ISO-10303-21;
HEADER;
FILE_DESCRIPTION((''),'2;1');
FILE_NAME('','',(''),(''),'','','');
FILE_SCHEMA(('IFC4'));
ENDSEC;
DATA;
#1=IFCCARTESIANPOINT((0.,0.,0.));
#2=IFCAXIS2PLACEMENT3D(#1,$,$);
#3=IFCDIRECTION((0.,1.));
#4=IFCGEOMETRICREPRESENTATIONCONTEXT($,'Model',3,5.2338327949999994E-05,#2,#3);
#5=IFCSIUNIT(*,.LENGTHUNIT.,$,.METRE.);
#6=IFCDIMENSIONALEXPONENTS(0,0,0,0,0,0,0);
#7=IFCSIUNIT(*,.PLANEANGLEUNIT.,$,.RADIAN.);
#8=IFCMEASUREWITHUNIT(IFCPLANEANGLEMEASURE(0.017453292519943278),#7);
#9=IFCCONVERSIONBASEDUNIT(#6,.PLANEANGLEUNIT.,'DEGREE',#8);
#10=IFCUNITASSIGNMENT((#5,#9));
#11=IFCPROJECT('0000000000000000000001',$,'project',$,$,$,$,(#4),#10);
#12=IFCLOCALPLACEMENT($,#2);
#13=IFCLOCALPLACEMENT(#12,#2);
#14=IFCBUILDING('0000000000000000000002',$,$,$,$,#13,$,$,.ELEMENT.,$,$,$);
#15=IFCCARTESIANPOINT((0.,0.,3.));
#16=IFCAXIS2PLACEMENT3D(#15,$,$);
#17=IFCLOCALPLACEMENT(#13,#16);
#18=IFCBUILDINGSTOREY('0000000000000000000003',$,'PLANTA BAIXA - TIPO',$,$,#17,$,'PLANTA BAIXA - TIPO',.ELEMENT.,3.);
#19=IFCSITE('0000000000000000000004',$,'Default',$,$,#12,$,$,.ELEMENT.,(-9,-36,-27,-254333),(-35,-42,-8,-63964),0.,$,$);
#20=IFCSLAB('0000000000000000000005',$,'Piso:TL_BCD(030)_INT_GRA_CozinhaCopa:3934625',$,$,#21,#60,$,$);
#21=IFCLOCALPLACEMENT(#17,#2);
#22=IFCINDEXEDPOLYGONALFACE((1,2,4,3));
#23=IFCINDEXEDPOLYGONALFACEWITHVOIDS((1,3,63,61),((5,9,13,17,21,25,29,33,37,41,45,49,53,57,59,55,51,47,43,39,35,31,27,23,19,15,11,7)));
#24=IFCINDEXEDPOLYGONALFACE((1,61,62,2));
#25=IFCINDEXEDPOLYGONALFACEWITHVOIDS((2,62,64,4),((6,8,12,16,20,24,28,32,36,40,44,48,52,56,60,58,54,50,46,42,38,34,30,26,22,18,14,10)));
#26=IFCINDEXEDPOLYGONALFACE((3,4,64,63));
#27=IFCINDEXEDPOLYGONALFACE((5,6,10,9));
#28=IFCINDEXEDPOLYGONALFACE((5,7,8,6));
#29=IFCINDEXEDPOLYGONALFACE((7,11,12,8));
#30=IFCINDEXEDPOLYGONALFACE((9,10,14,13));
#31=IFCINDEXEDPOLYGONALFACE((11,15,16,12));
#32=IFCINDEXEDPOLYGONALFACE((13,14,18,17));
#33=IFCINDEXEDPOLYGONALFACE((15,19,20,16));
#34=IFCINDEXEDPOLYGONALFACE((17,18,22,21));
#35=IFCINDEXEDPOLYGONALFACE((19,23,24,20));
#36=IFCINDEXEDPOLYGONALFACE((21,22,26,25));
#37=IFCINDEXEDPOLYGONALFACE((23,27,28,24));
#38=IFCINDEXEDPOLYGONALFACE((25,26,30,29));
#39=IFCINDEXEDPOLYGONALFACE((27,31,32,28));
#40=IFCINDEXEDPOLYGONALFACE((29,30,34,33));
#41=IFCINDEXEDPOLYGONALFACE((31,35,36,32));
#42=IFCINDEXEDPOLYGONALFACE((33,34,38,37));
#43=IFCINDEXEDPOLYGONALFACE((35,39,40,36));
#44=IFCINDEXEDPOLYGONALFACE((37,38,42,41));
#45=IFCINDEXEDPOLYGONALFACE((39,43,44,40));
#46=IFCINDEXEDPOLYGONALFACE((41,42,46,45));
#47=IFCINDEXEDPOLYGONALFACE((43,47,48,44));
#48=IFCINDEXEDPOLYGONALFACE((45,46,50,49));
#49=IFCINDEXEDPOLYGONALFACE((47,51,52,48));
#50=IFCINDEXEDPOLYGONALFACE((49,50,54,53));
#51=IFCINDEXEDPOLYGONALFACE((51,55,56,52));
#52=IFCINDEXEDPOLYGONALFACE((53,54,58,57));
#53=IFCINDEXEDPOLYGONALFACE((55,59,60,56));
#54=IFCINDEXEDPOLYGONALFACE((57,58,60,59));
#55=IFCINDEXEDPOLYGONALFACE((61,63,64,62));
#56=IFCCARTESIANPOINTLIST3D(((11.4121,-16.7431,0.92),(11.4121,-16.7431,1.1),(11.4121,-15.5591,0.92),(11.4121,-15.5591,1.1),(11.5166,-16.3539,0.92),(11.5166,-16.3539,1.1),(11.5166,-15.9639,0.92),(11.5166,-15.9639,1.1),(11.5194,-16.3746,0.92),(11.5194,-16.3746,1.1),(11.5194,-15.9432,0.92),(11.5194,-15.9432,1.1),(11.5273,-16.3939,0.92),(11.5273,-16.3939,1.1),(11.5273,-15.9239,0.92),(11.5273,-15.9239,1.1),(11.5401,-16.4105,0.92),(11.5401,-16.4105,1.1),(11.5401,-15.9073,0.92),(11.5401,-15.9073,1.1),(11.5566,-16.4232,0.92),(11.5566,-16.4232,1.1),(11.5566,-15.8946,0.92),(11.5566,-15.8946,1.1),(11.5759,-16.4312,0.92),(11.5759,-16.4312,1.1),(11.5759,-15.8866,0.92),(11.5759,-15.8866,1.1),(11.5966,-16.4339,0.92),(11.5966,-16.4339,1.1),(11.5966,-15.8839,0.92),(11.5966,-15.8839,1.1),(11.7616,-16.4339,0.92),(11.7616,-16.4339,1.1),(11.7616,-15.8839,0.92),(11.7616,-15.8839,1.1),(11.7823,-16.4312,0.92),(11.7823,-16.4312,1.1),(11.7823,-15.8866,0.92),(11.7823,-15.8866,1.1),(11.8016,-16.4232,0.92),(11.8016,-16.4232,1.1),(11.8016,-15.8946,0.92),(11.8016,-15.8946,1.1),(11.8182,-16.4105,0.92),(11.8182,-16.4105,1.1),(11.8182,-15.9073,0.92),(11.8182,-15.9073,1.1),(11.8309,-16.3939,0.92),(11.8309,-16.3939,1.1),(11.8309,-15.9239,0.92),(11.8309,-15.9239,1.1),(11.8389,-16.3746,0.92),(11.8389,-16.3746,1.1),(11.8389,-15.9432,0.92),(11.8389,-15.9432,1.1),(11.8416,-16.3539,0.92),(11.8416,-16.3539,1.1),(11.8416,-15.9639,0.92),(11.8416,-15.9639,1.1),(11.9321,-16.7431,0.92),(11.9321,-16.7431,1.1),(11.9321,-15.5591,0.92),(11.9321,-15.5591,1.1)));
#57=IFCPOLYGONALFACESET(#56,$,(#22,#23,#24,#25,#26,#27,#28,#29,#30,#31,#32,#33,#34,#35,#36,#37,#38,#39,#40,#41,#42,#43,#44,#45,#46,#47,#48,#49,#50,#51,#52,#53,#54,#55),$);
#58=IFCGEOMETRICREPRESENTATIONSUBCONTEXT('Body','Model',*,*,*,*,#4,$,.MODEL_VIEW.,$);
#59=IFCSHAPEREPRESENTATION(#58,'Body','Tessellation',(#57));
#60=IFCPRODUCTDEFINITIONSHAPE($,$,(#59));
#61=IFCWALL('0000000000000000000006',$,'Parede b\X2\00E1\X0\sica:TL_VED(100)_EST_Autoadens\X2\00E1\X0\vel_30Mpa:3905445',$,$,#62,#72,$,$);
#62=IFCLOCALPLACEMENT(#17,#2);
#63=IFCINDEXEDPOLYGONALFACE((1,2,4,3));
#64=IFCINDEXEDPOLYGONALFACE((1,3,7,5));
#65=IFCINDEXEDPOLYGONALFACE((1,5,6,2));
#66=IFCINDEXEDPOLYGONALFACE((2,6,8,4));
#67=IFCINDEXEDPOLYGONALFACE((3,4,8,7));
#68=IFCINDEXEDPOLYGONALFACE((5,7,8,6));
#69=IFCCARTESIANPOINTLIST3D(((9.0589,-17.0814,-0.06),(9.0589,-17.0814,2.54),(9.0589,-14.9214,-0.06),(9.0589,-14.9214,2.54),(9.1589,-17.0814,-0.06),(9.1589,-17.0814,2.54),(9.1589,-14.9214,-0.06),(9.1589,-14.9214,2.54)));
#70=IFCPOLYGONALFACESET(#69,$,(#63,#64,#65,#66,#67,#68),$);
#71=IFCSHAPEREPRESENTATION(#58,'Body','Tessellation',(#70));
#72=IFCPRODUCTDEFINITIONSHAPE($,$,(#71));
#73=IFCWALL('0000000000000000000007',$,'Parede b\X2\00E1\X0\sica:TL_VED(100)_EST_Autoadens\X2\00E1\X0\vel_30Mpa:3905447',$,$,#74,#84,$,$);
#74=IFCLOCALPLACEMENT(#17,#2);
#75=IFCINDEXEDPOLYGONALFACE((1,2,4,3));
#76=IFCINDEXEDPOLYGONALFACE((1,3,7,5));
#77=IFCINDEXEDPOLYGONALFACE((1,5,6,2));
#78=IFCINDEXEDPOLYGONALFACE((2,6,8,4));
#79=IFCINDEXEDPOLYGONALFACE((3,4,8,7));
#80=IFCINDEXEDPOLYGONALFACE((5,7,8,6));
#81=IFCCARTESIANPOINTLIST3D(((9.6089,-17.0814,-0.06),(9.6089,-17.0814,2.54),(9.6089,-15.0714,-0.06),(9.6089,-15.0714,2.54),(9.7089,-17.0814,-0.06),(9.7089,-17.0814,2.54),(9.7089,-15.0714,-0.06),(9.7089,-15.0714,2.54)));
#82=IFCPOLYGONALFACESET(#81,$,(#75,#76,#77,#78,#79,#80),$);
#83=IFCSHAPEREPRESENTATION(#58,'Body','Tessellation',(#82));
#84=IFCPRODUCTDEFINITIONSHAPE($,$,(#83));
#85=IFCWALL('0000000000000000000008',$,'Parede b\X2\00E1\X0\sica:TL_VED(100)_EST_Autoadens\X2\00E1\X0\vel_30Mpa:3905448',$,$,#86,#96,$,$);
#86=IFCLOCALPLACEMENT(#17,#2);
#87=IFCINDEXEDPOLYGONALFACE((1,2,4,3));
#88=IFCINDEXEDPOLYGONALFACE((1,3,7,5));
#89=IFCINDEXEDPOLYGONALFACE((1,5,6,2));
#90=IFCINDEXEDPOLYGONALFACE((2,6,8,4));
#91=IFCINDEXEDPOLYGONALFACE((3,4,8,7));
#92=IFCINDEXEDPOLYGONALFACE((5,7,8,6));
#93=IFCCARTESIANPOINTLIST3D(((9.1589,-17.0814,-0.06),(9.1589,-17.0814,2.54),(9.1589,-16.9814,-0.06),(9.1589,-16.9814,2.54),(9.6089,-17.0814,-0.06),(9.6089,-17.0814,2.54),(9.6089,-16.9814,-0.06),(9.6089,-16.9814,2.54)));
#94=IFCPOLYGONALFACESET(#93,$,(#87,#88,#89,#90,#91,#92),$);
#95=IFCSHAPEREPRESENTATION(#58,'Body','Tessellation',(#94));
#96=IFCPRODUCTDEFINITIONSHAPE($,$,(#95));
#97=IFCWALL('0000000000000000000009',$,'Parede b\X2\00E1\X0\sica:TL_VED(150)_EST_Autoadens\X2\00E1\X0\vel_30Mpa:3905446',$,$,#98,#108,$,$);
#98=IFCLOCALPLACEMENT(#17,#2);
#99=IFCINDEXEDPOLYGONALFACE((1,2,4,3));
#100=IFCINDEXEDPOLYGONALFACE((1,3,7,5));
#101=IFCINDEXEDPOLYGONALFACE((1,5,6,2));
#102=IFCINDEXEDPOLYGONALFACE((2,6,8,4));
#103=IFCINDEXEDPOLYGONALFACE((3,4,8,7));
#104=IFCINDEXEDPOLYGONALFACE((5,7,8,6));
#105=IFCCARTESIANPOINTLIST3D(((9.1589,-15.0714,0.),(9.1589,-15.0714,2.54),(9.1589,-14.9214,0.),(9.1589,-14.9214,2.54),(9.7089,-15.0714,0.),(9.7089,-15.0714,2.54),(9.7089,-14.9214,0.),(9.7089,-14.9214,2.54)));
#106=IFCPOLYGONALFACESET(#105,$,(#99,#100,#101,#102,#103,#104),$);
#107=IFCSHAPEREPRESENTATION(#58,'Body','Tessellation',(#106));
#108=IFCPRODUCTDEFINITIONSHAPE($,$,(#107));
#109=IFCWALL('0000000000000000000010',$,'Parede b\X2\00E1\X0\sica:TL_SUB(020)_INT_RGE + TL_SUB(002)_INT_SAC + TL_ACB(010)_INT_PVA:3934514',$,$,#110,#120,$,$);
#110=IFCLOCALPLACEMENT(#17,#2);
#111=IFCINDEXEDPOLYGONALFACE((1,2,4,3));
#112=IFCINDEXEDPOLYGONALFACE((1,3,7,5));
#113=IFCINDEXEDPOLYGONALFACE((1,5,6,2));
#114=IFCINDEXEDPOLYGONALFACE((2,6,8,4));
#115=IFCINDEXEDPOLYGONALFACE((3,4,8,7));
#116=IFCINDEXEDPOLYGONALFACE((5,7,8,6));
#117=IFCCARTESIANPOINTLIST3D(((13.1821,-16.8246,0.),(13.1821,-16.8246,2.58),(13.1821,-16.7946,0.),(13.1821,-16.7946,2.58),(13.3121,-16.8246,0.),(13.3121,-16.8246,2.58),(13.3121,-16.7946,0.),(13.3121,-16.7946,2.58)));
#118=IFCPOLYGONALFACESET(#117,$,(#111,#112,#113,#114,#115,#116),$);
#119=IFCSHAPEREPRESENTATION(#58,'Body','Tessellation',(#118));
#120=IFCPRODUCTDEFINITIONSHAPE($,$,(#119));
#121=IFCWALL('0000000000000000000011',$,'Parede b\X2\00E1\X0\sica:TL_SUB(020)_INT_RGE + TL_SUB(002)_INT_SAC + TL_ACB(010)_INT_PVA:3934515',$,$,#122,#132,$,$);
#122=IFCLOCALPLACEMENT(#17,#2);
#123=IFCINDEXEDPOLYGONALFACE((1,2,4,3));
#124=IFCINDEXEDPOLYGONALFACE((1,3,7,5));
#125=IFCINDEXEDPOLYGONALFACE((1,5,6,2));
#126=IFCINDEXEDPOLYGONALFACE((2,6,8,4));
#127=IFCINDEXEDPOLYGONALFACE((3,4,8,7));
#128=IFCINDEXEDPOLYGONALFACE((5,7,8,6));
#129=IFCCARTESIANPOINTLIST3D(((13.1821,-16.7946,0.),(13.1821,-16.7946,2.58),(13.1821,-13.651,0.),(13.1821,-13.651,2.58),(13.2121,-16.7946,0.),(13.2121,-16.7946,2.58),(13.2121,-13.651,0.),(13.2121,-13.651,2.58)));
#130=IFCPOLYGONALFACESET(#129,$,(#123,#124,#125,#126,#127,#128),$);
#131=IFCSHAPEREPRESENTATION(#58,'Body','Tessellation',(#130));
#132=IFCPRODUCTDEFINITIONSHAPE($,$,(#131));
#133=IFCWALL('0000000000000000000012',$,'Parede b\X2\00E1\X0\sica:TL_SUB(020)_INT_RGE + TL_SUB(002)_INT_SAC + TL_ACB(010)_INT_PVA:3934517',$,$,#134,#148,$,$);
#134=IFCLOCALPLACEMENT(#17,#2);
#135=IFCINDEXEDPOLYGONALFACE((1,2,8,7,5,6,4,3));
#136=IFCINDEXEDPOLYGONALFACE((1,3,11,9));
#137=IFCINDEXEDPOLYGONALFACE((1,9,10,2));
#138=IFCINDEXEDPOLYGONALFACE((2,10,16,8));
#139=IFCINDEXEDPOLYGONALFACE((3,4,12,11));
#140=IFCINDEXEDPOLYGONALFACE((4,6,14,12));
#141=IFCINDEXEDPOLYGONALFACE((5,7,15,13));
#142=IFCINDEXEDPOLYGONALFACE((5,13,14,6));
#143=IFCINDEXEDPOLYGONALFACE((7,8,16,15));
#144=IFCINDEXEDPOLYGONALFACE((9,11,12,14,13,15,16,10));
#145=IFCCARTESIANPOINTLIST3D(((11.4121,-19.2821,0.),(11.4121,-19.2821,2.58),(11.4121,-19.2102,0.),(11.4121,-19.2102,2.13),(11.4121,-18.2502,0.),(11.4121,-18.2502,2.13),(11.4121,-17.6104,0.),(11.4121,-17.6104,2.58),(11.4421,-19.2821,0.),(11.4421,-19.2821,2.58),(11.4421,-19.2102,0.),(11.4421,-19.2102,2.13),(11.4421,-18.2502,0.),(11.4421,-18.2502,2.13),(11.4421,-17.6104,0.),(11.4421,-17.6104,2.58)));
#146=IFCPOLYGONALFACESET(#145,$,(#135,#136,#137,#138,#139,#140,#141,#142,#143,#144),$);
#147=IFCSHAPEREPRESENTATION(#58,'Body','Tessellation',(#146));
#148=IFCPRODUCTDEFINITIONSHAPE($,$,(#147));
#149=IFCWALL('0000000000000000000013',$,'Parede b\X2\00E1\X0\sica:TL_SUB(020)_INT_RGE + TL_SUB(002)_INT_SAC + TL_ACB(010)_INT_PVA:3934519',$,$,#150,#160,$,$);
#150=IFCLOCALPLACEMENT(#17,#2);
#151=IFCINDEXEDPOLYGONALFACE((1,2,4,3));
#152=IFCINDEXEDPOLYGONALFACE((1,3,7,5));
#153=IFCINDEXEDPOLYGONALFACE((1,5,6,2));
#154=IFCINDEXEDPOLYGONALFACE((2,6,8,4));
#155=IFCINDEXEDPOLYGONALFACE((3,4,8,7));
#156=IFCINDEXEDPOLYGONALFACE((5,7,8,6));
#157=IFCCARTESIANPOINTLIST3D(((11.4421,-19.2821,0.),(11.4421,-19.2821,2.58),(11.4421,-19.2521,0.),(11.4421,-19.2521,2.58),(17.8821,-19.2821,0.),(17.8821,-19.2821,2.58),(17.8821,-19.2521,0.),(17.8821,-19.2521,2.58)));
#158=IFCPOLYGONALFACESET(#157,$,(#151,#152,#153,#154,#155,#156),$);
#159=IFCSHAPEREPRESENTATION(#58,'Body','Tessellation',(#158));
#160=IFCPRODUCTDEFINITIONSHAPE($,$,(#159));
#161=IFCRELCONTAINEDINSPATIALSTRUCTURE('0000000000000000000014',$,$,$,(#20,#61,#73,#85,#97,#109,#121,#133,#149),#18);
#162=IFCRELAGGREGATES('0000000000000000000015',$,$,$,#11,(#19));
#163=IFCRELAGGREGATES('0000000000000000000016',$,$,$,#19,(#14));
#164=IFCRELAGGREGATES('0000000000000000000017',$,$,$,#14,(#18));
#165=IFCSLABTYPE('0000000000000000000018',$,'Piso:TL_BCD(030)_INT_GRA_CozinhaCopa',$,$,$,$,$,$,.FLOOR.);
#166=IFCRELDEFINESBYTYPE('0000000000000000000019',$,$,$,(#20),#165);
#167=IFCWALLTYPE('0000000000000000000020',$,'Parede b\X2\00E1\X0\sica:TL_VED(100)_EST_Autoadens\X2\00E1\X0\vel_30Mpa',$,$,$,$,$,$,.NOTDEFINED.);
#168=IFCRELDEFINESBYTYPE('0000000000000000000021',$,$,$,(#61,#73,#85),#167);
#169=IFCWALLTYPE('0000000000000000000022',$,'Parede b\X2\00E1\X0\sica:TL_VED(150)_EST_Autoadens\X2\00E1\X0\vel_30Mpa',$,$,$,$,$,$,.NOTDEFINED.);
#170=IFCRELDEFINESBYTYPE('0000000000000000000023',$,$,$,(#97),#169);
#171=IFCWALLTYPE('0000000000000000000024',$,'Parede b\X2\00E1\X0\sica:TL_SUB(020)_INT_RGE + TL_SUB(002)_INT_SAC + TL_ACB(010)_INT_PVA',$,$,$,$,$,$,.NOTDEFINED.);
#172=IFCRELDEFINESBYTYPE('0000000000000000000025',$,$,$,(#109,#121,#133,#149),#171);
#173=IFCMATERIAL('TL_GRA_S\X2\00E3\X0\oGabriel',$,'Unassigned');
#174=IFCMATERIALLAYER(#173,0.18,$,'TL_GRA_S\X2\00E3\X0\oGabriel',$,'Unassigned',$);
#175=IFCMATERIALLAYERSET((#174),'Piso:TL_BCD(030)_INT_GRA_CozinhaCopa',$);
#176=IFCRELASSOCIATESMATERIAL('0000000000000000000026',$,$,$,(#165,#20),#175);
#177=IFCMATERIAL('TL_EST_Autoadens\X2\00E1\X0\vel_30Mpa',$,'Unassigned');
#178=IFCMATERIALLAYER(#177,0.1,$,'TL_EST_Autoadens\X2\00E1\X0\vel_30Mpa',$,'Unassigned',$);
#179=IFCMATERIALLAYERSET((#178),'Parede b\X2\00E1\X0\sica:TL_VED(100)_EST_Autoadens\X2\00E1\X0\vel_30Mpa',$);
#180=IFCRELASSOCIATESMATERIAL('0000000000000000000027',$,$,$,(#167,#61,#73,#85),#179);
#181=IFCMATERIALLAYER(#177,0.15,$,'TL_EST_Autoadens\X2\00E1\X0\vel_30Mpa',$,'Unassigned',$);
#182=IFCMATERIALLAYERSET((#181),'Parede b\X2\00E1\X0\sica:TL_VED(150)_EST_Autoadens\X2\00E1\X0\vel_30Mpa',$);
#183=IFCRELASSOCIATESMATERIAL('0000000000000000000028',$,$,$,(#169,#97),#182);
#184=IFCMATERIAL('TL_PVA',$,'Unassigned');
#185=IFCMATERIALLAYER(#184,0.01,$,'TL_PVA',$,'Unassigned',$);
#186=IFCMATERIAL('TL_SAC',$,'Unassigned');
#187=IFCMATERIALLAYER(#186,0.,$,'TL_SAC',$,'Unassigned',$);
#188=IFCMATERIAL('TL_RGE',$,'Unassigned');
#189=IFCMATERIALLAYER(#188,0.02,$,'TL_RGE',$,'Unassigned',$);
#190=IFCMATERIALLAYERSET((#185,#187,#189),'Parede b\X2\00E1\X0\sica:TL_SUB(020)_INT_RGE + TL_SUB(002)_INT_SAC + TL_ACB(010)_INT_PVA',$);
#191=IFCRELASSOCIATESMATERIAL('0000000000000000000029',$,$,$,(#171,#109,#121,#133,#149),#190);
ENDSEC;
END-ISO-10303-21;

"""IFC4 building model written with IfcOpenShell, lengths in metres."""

from ifc_helpers import new_model, entity, si_unit, converted_unit, direction, frame, frame_2d, origin, place, context, subcontext, project, spatial, polyline, circle_curve, parameter, trimmed, segment, composite_curve, rectangle, outline, extrude, material, layer, layer_set, layer_usage, type_object, element, save


model = new_model("IFC4")

# Units and contexts
model_context = context("Model", 3, precision=5.2338327949999994e-05, world=origin(), true_north=direction((0.0, 1.0)))
body_context = subcontext(model_context, "Body", "Model", "MODEL_VIEW")
ifc_project = project(units=[si_unit("LENGTHUNIT", "METRE"), converted_unit("PLANEANGLEUNIT", "DEGREE", entity("IfcPlaneAngleMeasure", 0.017453292519943278), si_unit("PLANEANGLEUNIT", "RADIAN"), dimensions=[0, 0, 0, 0, 0, 0, 0])], contexts=[model_context])

# Site, building, storey
site_placement = place(None, frame((0.0, 0.0, 0.0)))
site = spatial("IfcSite", under=ifc_project, at=site_placement, Name="Default", CompositionType="ELEMENT", RefLatitude=(-9, -36, -27, -254333), RefLongitude=(-35, -42, -8, -63964), RefElevation=0.0)
building_placement = place(site_placement, origin())
building = spatial("IfcBuilding", under=site, at=building_placement, CompositionType="ELEMENT")
storey_placement = place(building_placement, frame((0.0, 0.0, 3.0)))
storey = spatial("IfcBuildingStorey", under=building, at=storey_placement, Name="PLANTA BAIXA - TIPO", LongName="PLANTA BAIXA - TIPO", CompositionType="ELEMENT", Elevation=3.0)

# Slab, opening
ifc_material_1 = material(Name="TL_GRA_SãoGabriel", Category="Unassigned")
ifc_layer_1 = layer(ifc_material_1, 0.18, Name="TL_GRA_SãoGabriel", Category="Unassigned")
ifc_layer_set_1 = layer_set([ifc_layer_1], Name="Piso:TL_BCD(030)_INT_GRA_CozinhaCopa")
ifc_layer_usage_1 = layer_usage(ifc_layer_set_1, "AXIS3", "POSITIVE", 0.0)
slab_type_1 = type_object("IfcSlabType", Name="Piso:TL_BCD(030)_INT_GRA_CozinhaCopa", PredefinedType="FLOOR", material=ifc_layer_set_1)
slab_1_placement = place(storey_placement, frame((11.4121, -16.7431, 0.92)))
slab_1 = element("IfcSlab", 1, at=slab_1_placement, inside=storey, type_object=slab_type_1, material=ifc_layer_usage_1, Name="Piso:TL_BCD(030)_INT_GRA_CozinhaCopa:3934625", context=body_context, shape_type="SweptSolid", body=[
    extrude(rectangle(XDim=0.52, YDim=1.184, at=frame_2d((0.0, 0.0), x_axis=(-1.0, 0.0))), frame((0.26, 0.592, 0.18), z_axis=(0.0, 0.0, -1.0), x_axis=(-1.0, 0.0, 0.0)), (0.0, 0.0, 1.0), 0.18),
])
opening_1_placement = place(slab_1_placement, frame((-11.4121, 16.7431, 0.18)))
element("IfcOpeningElement", 2, at=opening_1_placement, cuts=slab_1, PredefinedType="OPENING", context=body_context, shape_type="SweptSolid", body=[
    extrude(outline(composite_curve([segment(trimmed(circle_curve(frame_2d((0.195, -0.0825), x_axis=(1.0, 0.0)), 0.08), [parameter(270.0)], [parameter(0.0)], True, "PARAMETER"), True, "CONTINUOUS"), segment(polyline([(0.275, -0.0825), (0.275, 0.0825)]), True, "CONTINUOUS"), segment(trimmed(circle_curve(frame_2d((0.195, 0.0825), x_axis=(1.0, 0.0)), 0.08), [parameter(0.0)], [parameter(90.0)], True, "PARAMETER"), True, "CONTINUOUS"), segment(polyline([(0.195, 0.1625), (-0.195, 0.1625)]), True, "CONTINUOUS"), segment(trimmed(circle_curve(frame_2d((-0.195, 0.0825), x_axis=(1.0, 0.0)), 0.08), [parameter(90.0)], [parameter(180.0)], True, "PARAMETER"), True, "CONTINUOUS"), segment(polyline([(-0.275, 0.0825), (-0.275, -0.0825)]), True, "CONTINUOUS"), segment(trimmed(circle_curve(frame_2d((-0.195, -0.0825), x_axis=(1.0, 0.0)), 0.08), [parameter(180.0)], [parameter(270.0)], True, "PARAMETER"), True, "CONTINUOUS"), segment(polyline([(-0.195, -0.1625), (0.195, -0.1625)]), True, "CONTINUOUS")], self_intersect=False)), frame((11.6791, -16.1589, -0.21), z_axis=(0.0, 0.0, 1.0), x_axis=(0.0, -1.0, 0.0)), (0.0, 0.0, 1.0), 0.21),
])

# Walls
ifc_material_2 = material(Name="TL_EST_Autoadensável_30Mpa", Category="Unassigned")
ifc_layer_2 = layer(ifc_material_2, 0.1, Name="TL_EST_Autoadensável_30Mpa", Category="Unassigned")
ifc_layer_set_2 = layer_set([ifc_layer_2], Name="Parede básica:TL_VED(100)_EST_Autoadensável_30Mpa")
ifc_layer_usage_2 = layer_usage(ifc_layer_set_2, "AXIS2", "NEGATIVE", 0.05)
wall_type_1 = type_object("IfcWallType", Name="Parede básica:TL_VED(100)_EST_Autoadensável_30Mpa", PredefinedType="NOTDEFINED", material=ifc_layer_set_2)
wall_1_placement = place(storey_placement, frame((9.1089, -17.0814, -0.06), z_axis=(0.0, 0.0, 1.0), x_axis=(0.0, 1.0, 0.0)))
element("IfcWall", 3, at=wall_1_placement, inside=storey, type_object=wall_type_1, material=ifc_layer_usage_2, Name="Parede básica:TL_VED(100)_EST_Autoadensável_30Mpa:3905445", context=body_context, shape_type="SweptSolid", body=[
    extrude(rectangle(XDim=2.16, YDim=0.1, at=frame_2d((1.08, 0.0), x_axis=(-1.0, 0.0))), origin(), (0.0, 0.0, 1.0), 2.6),
])
ifc_layer_usage_3 = layer_usage(ifc_layer_set_2, "AXIS2", "NEGATIVE", 0.05)
wall_2_placement = place(storey_placement, frame((9.6589, -15.0714, -0.06), z_axis=(0.0, 0.0, 1.0), x_axis=(0.0, -1.0, 0.0)))
element("IfcWall", 4, at=wall_2_placement, inside=storey, type_object=wall_type_1, material=ifc_layer_usage_3, Name="Parede básica:TL_VED(100)_EST_Autoadensável_30Mpa:3905447", context=body_context, shape_type="SweptSolid", body=[
    extrude(rectangle(XDim=2.01, YDim=0.1, at=frame_2d((1.005, 0.0), x_axis=(-1.0, 0.0))), origin(), (0.0, 0.0, 1.0), 2.6),
])
ifc_layer_usage_4 = layer_usage(ifc_layer_set_2, "AXIS2", "NEGATIVE", 0.05)
wall_3_placement = place(storey_placement, frame((9.6089, -17.0314, -0.06), z_axis=(0.0, 0.0, 1.0), x_axis=(-1.0, 0.0, 0.0)))
element("IfcWall", 5, at=wall_3_placement, inside=storey, type_object=wall_type_1, material=ifc_layer_usage_4, Name="Parede básica:TL_VED(100)_EST_Autoadensável_30Mpa:3905448", context=body_context, shape_type="SweptSolid", body=[
    extrude(rectangle(XDim=0.45, YDim=0.1, at=frame_2d((0.225, 0.0), x_axis=(-1.0, 0.0))), origin(), (0.0, 0.0, 1.0), 2.6),
])
ifc_layer_3 = layer(ifc_material_2, 0.15, Name="TL_EST_Autoadensável_30Mpa", Category="Unassigned")
ifc_layer_set_3 = layer_set([ifc_layer_3], Name="Parede básica:TL_VED(150)_EST_Autoadensável_30Mpa")
ifc_layer_usage_5 = layer_usage(ifc_layer_set_3, "AXIS2", "NEGATIVE", 0.075)
wall_type_2 = type_object("IfcWallType", Name="Parede básica:TL_VED(150)_EST_Autoadensável_30Mpa", PredefinedType="NOTDEFINED", material=ifc_layer_set_3)
wall_4_placement = place(storey_placement, frame((9.1589, -14.9964, 0.0)))
element("IfcWall", 6, at=wall_4_placement, inside=storey, type_object=wall_type_2, material=ifc_layer_usage_5, Name="Parede básica:TL_VED(150)_EST_Autoadensável_30Mpa:3905446", context=body_context, shape_type="SweptSolid", body=[
    extrude(rectangle(XDim=0.55, YDim=0.15, at=frame_2d((0.275, 0.0), x_axis=(-1.0, 0.0))), origin(), (0.0, 0.0, 1.0), 2.54),
])
ifc_material_3 = material(Name="TL_PVA", Category="Unassigned")
ifc_layer_4 = layer(ifc_material_3, 0.01, Name="TL_PVA", Category="Unassigned")
ifc_material_4 = material(Name="TL_SAC", Category="Unassigned")
ifc_layer_5 = layer(ifc_material_4, 0.0, Name="TL_SAC", Category="Unassigned")
ifc_material_5 = material(Name="TL_RGE", Category="Unassigned")
ifc_layer_6 = layer(ifc_material_5, 0.02, Name="TL_RGE", Category="Unassigned")
ifc_layer_set_4 = layer_set([ifc_layer_4, ifc_layer_5, ifc_layer_6], Name="Parede básica:TL_SUB(020)_INT_RGE + TL_SUB(002)_INT_SAC + TL_ACB(010)_INT_PVA")
ifc_layer_usage_6 = layer_usage(ifc_layer_set_4, "AXIS2", "POSITIVE", -0.015)
wall_type_3 = type_object("IfcWallType", Name="Parede básica:TL_SUB(020)_INT_RGE + TL_SUB(002)_INT_SAC + TL_ACB(010)_INT_PVA", PredefinedType="NOTDEFINED", material=ifc_layer_set_4)
wall_5_placement = place(storey_placement, frame((13.1821, -16.8096, 0.0)))
element("IfcWall", 7, at=wall_5_placement, inside=storey, type_object=wall_type_3, material=ifc_layer_usage_6, Name="Parede básica:TL_SUB(020)_INT_RGE + TL_SUB(002)_INT_SAC + TL_ACB(010)_INT_PVA:3934514", context=body_context, shape_type="SweptSolid", body=[
    extrude(rectangle(XDim=0.13, YDim=0.03, at=frame_2d((0.065, 0.0), x_axis=(-1.0, 0.0))), origin(), (0.0, 0.0, 1.0), 2.58),
])
ifc_layer_usage_7 = layer_usage(ifc_layer_set_4, "AXIS2", "POSITIVE", -0.015)
wall_6_placement = place(storey_placement, frame((13.1971, -13.651, 0.0), z_axis=(0.0, 0.0, 1.0), x_axis=(0.0, -1.0, 0.0)))
element("IfcWall", 8, at=wall_6_placement, inside=storey, type_object=wall_type_3, material=ifc_layer_usage_7, Name="Parede básica:TL_SUB(020)_INT_RGE + TL_SUB(002)_INT_SAC + TL_ACB(010)_INT_PVA:3934515", context=body_context, shape_type="SweptSolid", body=[
    extrude(rectangle(XDim=3.1437, YDim=0.03, at=frame_2d((1.5718, 0.0), x_axis=(-1.0, 0.0))), origin(), (0.0, 0.0, 1.0), 2.58),
])

# Wall, opening
ifc_layer_usage_8 = layer_usage(ifc_layer_set_4, "AXIS2", "POSITIVE", -0.015)
wall_7_placement = place(storey_placement, frame((11.4271, -19.2821, 0.0), z_axis=(0.0, 0.0, 1.0), x_axis=(0.0, 1.0, 0.0)))
wall_7 = element("IfcWall", 9, at=wall_7_placement, inside=storey, type_object=wall_type_3, material=ifc_layer_usage_8, Name="Parede básica:TL_SUB(020)_INT_RGE + TL_SUB(002)_INT_SAC + TL_ACB(010)_INT_PVA:3934517", context=body_context, shape_type="SweptSolid", body=[
    extrude(rectangle(XDim=1.6717, YDim=0.03, at=frame_2d((0.8359, 0.0), x_axis=(-1.0, 0.0))), origin(), (0.0, 0.0, 1.0), 2.58),
])
opening_2_placement = place(wall_7_placement, frame((19.2821, 11.4271, 0.0)))
element("IfcOpeningElement", 10, at=opening_2_placement, cuts=wall_7, PredefinedType="OPENING", context=body_context, shape_type="SweptSolid", body=[
    extrude(rectangle(XDim=2.13, YDim=0.96, at=frame_2d((0.0, 0.0), x_axis=(0.0, 1.0))), frame((-18.7302, -12.9361, 1.065), z_axis=(0.0, 1.0, 0.0), x_axis=(-1.0, 0.0, 0.0)), (0.0, 0.0, 1.0), 3.048),
])

# Wall
ifc_layer_usage_9 = layer_usage(ifc_layer_set_4, "AXIS2", "NEGATIVE", 0.015)
wall_8_placement = place(storey_placement, frame((11.4421, -19.2671, 0.0)))
element("IfcWall", 11, at=wall_8_placement, inside=storey, type_object=wall_type_3, material=ifc_layer_usage_9, Name="Parede básica:TL_SUB(020)_INT_RGE + TL_SUB(002)_INT_SAC + TL_ACB(010)_INT_PVA:3934519", context=body_context, shape_type="SweptSolid", body=[
    extrude(rectangle(XDim=6.44, YDim=0.03, at=frame_2d((3.22, 0.0), x_axis=(-1.0, 0.0))), origin(), (0.0, 0.0, 1.0), 2.58),
])

save(model, "model.ifc")
